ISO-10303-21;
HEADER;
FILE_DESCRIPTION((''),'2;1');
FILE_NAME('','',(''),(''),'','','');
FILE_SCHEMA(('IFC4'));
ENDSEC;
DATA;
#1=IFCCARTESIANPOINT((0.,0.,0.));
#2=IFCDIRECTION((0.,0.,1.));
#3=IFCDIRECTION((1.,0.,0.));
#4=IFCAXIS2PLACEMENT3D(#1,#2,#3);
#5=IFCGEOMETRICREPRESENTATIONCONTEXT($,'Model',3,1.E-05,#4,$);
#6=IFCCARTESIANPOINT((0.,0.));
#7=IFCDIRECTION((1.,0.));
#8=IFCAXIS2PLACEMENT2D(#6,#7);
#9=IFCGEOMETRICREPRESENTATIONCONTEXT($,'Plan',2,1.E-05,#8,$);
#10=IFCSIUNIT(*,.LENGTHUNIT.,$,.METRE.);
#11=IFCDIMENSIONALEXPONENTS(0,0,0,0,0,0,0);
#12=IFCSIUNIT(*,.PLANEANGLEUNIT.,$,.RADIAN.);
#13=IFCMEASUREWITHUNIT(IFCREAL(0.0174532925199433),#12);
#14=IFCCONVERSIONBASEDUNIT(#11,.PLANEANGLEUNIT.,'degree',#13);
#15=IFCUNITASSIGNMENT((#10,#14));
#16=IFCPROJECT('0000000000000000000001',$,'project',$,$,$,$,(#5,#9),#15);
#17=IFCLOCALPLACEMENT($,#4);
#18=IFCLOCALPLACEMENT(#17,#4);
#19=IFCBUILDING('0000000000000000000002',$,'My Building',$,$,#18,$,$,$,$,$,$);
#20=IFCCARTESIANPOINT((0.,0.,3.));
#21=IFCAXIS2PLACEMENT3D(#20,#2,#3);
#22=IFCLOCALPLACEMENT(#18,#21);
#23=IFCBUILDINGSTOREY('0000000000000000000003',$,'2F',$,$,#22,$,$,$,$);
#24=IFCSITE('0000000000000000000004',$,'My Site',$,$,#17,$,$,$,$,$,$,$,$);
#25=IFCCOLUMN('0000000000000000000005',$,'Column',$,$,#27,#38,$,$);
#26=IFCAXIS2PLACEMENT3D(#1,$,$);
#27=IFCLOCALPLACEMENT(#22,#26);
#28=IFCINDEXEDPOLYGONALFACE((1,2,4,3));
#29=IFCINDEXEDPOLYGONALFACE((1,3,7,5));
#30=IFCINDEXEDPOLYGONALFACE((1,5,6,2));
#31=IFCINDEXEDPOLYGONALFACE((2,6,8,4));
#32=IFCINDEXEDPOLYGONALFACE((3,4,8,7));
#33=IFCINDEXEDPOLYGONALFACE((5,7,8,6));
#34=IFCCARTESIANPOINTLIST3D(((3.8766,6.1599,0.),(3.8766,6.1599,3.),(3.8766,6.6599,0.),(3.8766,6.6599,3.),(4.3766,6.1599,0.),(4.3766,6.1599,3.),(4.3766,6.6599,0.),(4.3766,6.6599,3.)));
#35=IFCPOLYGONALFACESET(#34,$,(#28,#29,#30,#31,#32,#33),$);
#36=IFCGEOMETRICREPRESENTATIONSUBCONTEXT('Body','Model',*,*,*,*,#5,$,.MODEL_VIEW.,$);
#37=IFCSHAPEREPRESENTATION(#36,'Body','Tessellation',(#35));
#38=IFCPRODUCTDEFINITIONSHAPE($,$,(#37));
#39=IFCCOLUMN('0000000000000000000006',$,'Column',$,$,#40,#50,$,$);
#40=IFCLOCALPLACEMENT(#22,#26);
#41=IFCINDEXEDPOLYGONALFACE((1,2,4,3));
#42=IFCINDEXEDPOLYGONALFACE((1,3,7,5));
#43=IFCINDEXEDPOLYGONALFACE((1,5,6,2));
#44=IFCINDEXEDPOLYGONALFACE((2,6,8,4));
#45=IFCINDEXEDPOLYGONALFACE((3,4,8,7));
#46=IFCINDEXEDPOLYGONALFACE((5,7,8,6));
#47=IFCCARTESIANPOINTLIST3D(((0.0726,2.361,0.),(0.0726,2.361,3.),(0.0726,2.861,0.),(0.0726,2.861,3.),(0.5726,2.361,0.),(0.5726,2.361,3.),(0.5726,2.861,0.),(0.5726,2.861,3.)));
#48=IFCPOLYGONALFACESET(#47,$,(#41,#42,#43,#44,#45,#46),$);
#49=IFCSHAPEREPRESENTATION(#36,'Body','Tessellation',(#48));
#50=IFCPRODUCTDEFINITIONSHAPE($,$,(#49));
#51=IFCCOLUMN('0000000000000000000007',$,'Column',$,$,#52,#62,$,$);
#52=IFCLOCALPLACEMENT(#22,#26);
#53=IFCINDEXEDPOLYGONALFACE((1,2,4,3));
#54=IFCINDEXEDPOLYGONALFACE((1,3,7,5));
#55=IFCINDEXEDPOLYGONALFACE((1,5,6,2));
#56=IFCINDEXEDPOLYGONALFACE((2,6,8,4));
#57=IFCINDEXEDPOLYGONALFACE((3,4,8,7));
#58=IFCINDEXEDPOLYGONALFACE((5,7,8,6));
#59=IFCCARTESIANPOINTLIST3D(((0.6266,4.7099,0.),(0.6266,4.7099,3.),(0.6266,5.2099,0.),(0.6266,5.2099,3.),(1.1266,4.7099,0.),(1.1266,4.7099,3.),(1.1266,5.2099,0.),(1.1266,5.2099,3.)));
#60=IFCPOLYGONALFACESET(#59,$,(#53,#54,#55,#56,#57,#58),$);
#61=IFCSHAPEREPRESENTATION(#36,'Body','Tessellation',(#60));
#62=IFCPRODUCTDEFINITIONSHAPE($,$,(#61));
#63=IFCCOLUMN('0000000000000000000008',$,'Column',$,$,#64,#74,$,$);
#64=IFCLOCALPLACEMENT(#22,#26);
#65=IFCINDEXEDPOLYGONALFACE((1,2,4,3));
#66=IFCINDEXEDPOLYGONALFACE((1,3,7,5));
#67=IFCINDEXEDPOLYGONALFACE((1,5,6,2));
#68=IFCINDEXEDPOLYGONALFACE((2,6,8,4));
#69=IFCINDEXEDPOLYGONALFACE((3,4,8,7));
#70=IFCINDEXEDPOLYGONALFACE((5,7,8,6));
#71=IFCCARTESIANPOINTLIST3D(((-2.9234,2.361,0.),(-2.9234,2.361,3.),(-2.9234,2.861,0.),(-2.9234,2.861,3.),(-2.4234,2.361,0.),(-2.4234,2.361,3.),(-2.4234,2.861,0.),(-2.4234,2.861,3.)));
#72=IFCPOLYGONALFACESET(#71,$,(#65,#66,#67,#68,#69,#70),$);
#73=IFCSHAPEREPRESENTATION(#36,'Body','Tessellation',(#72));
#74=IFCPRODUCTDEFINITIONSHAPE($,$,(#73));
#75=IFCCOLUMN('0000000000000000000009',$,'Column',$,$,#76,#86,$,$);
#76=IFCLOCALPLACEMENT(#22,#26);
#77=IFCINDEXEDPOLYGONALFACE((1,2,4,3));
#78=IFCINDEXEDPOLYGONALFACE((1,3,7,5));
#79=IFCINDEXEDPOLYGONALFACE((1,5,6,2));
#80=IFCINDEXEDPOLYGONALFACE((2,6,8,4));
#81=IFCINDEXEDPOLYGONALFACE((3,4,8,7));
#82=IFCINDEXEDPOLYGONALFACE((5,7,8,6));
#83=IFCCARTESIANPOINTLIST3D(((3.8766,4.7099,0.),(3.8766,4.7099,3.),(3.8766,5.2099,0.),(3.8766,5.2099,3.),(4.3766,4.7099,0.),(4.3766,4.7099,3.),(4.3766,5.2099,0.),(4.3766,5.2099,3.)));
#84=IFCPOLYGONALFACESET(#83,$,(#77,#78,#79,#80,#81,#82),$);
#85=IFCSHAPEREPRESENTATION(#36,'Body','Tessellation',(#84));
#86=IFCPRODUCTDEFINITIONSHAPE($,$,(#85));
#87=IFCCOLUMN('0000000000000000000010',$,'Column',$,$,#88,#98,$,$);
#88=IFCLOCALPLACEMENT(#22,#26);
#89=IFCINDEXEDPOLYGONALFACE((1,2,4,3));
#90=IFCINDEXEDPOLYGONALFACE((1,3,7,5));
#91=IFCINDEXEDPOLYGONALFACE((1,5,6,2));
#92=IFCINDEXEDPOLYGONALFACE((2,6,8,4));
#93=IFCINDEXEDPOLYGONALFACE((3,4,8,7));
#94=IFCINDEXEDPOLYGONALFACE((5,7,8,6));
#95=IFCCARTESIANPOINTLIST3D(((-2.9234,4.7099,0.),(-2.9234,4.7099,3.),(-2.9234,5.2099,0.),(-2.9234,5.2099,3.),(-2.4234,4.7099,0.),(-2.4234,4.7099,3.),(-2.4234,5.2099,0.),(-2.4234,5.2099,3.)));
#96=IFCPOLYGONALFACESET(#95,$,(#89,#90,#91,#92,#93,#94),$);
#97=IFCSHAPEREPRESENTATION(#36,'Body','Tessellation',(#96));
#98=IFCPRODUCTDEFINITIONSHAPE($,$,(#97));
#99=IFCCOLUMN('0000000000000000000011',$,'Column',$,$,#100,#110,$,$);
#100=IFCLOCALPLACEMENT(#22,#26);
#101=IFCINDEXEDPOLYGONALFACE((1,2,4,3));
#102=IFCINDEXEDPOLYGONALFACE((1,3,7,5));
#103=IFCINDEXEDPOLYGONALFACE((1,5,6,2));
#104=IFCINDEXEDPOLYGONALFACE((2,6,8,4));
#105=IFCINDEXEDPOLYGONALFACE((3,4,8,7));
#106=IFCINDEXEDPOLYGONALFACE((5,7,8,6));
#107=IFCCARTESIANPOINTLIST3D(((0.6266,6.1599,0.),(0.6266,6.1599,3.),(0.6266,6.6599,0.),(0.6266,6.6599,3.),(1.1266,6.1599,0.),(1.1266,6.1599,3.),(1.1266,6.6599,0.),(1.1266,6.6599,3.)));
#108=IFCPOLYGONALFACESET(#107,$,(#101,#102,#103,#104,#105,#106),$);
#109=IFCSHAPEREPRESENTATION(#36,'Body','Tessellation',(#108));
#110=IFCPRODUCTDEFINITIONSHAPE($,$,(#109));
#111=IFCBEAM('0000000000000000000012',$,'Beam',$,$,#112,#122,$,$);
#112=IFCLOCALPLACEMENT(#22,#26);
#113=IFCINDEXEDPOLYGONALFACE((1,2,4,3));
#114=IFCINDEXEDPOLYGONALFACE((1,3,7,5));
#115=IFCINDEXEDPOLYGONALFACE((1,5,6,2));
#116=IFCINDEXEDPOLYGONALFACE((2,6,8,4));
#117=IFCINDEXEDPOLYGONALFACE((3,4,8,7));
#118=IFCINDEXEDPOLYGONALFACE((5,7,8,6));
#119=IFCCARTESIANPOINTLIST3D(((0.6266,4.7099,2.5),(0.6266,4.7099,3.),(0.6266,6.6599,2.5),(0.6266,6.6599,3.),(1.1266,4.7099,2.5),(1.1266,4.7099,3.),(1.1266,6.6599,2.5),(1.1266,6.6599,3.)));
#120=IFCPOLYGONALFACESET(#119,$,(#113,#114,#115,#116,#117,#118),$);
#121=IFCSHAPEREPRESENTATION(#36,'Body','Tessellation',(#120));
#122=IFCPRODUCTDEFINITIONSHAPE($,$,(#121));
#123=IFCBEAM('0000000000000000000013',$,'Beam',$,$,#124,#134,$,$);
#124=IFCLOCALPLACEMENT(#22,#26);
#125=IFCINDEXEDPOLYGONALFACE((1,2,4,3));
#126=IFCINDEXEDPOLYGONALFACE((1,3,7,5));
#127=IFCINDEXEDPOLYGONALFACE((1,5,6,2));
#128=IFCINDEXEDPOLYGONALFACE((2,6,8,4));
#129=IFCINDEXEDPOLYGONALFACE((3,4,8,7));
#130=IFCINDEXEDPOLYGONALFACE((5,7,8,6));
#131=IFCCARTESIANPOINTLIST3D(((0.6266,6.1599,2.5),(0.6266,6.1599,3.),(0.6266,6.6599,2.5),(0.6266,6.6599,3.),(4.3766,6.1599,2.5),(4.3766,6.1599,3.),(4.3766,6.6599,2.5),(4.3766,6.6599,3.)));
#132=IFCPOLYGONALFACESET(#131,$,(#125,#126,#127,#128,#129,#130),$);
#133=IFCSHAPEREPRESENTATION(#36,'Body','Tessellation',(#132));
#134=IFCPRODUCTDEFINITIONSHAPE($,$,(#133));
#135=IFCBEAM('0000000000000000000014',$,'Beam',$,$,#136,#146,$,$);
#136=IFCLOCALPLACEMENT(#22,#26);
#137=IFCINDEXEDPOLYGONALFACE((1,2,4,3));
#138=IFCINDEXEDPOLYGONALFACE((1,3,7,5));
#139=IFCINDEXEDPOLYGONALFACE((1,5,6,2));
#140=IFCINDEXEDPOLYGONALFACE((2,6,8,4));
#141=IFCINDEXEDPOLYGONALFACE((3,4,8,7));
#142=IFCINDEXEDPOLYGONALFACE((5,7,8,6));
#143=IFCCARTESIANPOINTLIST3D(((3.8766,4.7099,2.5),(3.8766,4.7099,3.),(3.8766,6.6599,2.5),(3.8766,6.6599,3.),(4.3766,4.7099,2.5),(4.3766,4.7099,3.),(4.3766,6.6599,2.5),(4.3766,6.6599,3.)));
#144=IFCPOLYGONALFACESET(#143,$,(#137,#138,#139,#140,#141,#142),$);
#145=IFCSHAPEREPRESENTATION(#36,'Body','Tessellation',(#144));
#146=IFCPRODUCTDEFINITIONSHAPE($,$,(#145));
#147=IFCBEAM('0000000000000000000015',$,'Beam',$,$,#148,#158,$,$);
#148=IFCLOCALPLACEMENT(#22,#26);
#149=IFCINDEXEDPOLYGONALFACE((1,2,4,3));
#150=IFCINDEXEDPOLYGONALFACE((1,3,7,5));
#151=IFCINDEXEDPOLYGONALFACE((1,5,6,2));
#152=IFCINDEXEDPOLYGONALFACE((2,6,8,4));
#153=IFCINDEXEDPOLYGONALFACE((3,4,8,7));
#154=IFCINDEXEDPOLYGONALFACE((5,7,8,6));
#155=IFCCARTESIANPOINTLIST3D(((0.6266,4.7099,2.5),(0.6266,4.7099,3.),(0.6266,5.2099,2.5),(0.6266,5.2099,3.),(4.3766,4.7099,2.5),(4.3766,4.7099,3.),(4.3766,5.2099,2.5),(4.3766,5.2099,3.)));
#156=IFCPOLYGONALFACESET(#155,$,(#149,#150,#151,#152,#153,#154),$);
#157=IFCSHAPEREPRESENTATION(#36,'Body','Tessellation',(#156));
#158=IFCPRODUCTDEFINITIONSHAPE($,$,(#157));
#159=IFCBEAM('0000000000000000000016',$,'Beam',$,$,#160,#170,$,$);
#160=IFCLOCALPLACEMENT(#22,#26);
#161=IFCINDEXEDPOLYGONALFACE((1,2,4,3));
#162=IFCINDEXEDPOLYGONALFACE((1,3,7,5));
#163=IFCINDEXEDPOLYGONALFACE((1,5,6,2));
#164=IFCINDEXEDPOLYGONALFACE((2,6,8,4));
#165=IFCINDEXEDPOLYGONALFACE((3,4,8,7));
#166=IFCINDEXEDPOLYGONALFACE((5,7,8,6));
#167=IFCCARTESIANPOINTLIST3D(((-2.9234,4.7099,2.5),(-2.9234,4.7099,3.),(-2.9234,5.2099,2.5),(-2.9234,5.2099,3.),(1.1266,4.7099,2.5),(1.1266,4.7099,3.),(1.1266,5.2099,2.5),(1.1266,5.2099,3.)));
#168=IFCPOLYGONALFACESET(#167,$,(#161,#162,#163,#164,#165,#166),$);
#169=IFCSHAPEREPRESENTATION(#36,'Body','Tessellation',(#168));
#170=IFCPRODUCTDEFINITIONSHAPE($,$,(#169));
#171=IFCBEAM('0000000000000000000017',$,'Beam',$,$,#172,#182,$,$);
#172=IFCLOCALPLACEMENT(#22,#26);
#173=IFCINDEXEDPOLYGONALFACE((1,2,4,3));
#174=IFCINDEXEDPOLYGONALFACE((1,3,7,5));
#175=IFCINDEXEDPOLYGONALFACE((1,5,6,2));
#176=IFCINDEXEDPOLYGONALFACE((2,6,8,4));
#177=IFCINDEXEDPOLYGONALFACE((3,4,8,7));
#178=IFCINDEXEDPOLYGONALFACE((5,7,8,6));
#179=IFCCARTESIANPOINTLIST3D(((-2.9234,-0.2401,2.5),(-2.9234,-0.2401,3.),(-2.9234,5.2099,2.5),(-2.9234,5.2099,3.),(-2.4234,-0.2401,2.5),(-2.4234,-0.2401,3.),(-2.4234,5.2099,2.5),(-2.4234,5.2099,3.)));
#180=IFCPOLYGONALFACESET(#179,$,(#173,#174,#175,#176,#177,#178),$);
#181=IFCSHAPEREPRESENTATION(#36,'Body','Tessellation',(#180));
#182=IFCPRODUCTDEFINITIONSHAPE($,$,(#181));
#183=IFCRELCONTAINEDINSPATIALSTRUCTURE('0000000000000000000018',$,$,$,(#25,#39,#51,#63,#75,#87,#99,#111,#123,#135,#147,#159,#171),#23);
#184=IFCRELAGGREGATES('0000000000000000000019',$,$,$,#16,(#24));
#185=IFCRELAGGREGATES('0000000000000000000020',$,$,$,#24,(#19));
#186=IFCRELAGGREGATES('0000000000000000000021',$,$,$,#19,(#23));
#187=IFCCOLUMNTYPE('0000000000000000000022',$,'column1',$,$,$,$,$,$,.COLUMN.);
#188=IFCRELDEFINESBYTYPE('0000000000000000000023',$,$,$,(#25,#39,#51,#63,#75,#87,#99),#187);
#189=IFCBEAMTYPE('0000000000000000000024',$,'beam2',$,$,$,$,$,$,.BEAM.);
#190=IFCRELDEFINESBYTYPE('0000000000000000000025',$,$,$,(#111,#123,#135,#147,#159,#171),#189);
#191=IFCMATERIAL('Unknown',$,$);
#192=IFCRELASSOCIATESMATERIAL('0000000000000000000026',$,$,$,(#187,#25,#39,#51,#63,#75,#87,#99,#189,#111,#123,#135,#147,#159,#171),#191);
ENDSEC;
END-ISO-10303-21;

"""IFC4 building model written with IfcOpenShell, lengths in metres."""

from ifc_helpers import new_model, entity, si_unit, converted_unit, frame, origin_with_axes, origin_2d_with_axis, place, context, subcontext, project, spatial, rectangle, extrude, material, material_profile, profile_set, profile_usage, type_object, element, save


model = new_model("IFC4")

# Units and contexts
model_context = context("Model", 3, precision=1e-05, world=origin_with_axes())
plan_context = context("Plan", 2, precision=1e-05, world=origin_2d_with_axis())
body_context_1 = subcontext(model_context, "Body", "Model", "MODEL_VIEW")
ifc_project = project(units=[si_unit("LENGTHUNIT", "METRE"), converted_unit("PLANEANGLEUNIT", "degree", entity("IfcReal", 0.0174532925199433), si_unit("PLANEANGLEUNIT", "RADIAN"), dimensions=[0, 0, 0, 0, 0, 0, 0])], contexts=[model_context, plan_context])

# Site, building, storey
site_placement = place(None, origin_with_axes())
site = spatial("IfcSite", under=ifc_project, at=site_placement, Name="My Site")
building_placement = place(site_placement, origin_with_axes())
building = spatial("IfcBuilding", under=site, at=building_placement, Name="My Building")
storey_placement = place(building_placement, frame((0.0, 0.0, 3.0), z_axis=(0.0, 0.0, 1.0), x_axis=(1.0, 0.0, 0.0)))
storey = spatial("IfcBuildingStorey", under=building, at=storey_placement, Name="2F")

# Columns
ifc_material = material(Name="Unknown")
ifc_material_profile_1 = material_profile(ifc_material, rectangle(XDim=0.5, YDim=0.5))
ifc_profile_set_1 = profile_set([ifc_material_profile_1])
ifc_profile_usage_1 = profile_usage(ifc_profile_set_1, cardinal=7)
column_type = type_object("IfcColumnType", Name="column1", PredefinedType="COLUMN", material=ifc_profile_set_1)
column_1_placement = place(storey_placement, frame((4.3766, 6.6599, 0.0), z_axis=(0.0, 0.0, 1.0), x_axis=(1.0, 0.0, 0.0)))
element("IfcColumn", 1, at=column_1_placement, inside=storey, type_object=column_type, material=ifc_profile_usage_1, Name="Column", context=body_context_1, shape_type="SweptSolid", body=[
    extrude(rectangle(XDim=0.5, YDim=0.5), frame((-0.25, -0.25, 0.0), z_axis=(0.0, 0.0, 1.0), x_axis=(1.0, 0.0, 0.0)), (0.0, 0.0, 1.0), 3.0),
])
ifc_profile_usage_2 = profile_usage(ifc_profile_set_1, cardinal=7)
column_2_placement = place(storey_placement, frame((0.5726, 2.861, 0.0), z_axis=(0.0, 0.0, 1.0), x_axis=(1.0, 0.0, 0.0)))
element("IfcColumn", 2, at=column_2_placement, inside=storey, type_object=column_type, material=ifc_profile_usage_2, Name="Column", context=body_context_1, shape_type="SweptSolid", body=[
    extrude(rectangle(XDim=0.5, YDim=0.5), frame((-0.25, -0.25, 0.0), z_axis=(0.0, 0.0, 1.0), x_axis=(1.0, 0.0, 0.0)), (0.0, 0.0, 1.0), 3.0),
])
ifc_profile_usage_3 = profile_usage(ifc_profile_set_1, cardinal=7)
column_3_placement = place(storey_placement, frame((1.1266, 5.2099, 0.0), z_axis=(0.0, 0.0, 1.0), x_axis=(1.0, 0.0, 0.0)))
element("IfcColumn", 3, at=column_3_placement, inside=storey, type_object=column_type, material=ifc_profile_usage_3, Name="Column", context=body_context_1, shape_type="SweptSolid", body=[
    extrude(rectangle(XDim=0.5, YDim=0.5), frame((-0.25, -0.25, 0.0), z_axis=(0.0, 0.0, 1.0), x_axis=(1.0, 0.0, 0.0)), (0.0, 0.0, 1.0), 3.0),
])
ifc_profile_usage_4 = profile_usage(ifc_profile_set_1, cardinal=7)
column_4_placement = place(storey_placement, frame((-2.4234, 2.861, 0.0), z_axis=(0.0, 0.0, 1.0), x_axis=(1.0, 0.0, 0.0)))
element("IfcColumn", 4, at=column_4_placement, inside=storey, type_object=column_type, material=ifc_profile_usage_4, Name="Column", context=body_context_1, shape_type="SweptSolid", body=[
    extrude(rectangle(XDim=0.5, YDim=0.5), frame((-0.25, -0.25, 0.0), z_axis=(0.0, 0.0, 1.0), x_axis=(1.0, 0.0, 0.0)), (0.0, 0.0, 1.0), 3.0),
])
ifc_profile_usage_5 = profile_usage(ifc_profile_set_1, cardinal=7)
column_5_placement = place(storey_placement, frame((4.3766, 5.2099, 0.0), z_axis=(0.0, 0.0, 1.0), x_axis=(1.0, 0.0, 0.0)))
element("IfcColumn", 5, at=column_5_placement, inside=storey, type_object=column_type, material=ifc_profile_usage_5, Name="Column", context=body_context_1, shape_type="SweptSolid", body=[
    extrude(rectangle(XDim=0.5, YDim=0.5), frame((-0.25, -0.25, 0.0), z_axis=(0.0, 0.0, 1.0), x_axis=(1.0, 0.0, 0.0)), (0.0, 0.0, 1.0), 3.0),
])
ifc_profile_usage_6 = profile_usage(ifc_profile_set_1, cardinal=7)
column_6_placement = place(storey_placement, frame((-2.4234, 5.2099, 0.0), z_axis=(0.0, 0.0, 1.0), x_axis=(1.0, 0.0, 0.0)))
element("IfcColumn", 6, at=column_6_placement, inside=storey, type_object=column_type, material=ifc_profile_usage_6, Name="Column", context=body_context_1, shape_type="SweptSolid", body=[
    extrude(rectangle(XDim=0.5, YDim=0.5), frame((-0.25, -0.25, 0.0), z_axis=(0.0, 0.0, 1.0), x_axis=(1.0, 0.0, 0.0)), (0.0, 0.0, 1.0), 3.0),
])
ifc_profile_usage_7 = profile_usage(ifc_profile_set_1, cardinal=7)
column_7_placement = place(storey_placement, frame((1.1266, 6.6599, 0.0), z_axis=(0.0, 0.0, 1.0), x_axis=(1.0, 0.0, 0.0)))
element("IfcColumn", 7, at=column_7_placement, inside=storey, type_object=column_type, material=ifc_profile_usage_7, Name="Column", context=body_context_1, shape_type="SweptSolid", body=[
    extrude(rectangle(XDim=0.5, YDim=0.5), frame((-0.25, -0.25, 0.0), z_axis=(0.0, 0.0, 1.0), x_axis=(1.0, 0.0, 0.0)), (0.0, 0.0, 1.0), 3.0),
])

# Beams
ifc_material_profile_2 = material_profile(ifc_material, rectangle(XDim=0.5, YDim=0.5))
ifc_profile_set_2 = profile_set([ifc_material_profile_2])
ifc_profile_usage_8 = profile_usage(ifc_profile_set_2, cardinal=7)
beam_type = type_object("IfcBeamType", Name="beam2", PredefinedType="BEAM", material=ifc_profile_set_2)
beam_1_placement = place(storey_placement, frame((1.1266, 6.6599, 3.0), z_axis=(0.0, -1.0, 0.0), x_axis=(1.0, 0.0, 0.0)))
element("IfcBeam", 8, at=beam_1_placement, inside=storey, type_object=beam_type, material=ifc_profile_usage_8, Name="Beam", context=body_context_1, shape_type="SweptSolid", body=[
    extrude(rectangle(XDim=0.5, YDim=0.5), frame((-0.25, -0.25, 0.0), z_axis=(0.0, 0.0, 1.0), x_axis=(1.0, 0.0, 0.0)), (0.0, 0.0, 1.0), 1.95),
])
ifc_profile_usage_9 = profile_usage(ifc_profile_set_2, cardinal=7)
beam_2_placement = place(storey_placement, frame((0.6266, 6.6599, 3.0), z_axis=(1.0, 0.0, 0.0), x_axis=(0.0, 1.0, 0.0)))
element("IfcBeam", 9, at=beam_2_placement, inside=storey, type_object=beam_type, material=ifc_profile_usage_9, Name="Beam", context=body_context_1, shape_type="SweptSolid", body=[
    extrude(rectangle(XDim=0.5, YDim=0.5), frame((-0.25, -0.25, 0.0), z_axis=(0.0, 0.0, 1.0), x_axis=(1.0, 0.0, 0.0)), (0.0, 0.0, 1.0), 3.75),
])
ifc_profile_usage_10 = profile_usage(ifc_profile_set_2, cardinal=7)
beam_3_placement = place(storey_placement, frame((3.8766, 4.7099, 3.0), z_axis=(0.0, 1.0, 0.0), x_axis=(-1.0, 0.0, 0.0)))
element("IfcBeam", 10, at=beam_3_placement, inside=storey, type_object=beam_type, material=ifc_profile_usage_10, Name="Beam", context=body_context_1, shape_type="SweptSolid", body=[
    extrude(rectangle(XDim=0.5, YDim=0.5), frame((-0.25, -0.25, 0.0), z_axis=(0.0, 0.0, 1.0), x_axis=(1.0, 0.0, 0.0)), (0.0, 0.0, 1.0), 1.95),
])
ifc_profile_usage_11 = profile_usage(ifc_profile_set_2, cardinal=7)
beam_4_placement = place(storey_placement, frame((4.3766, 4.7099, 3.0), z_axis=(-1.0, 0.0, 0.0), x_axis=(0.0, -1.0, 0.0)))
element("IfcBeam", 11, at=beam_4_placement, inside=storey, type_object=beam_type, material=ifc_profile_usage_11, Name="Beam", context=body_context_1, shape_type="SweptSolid", body=[
    extrude(rectangle(XDim=0.5, YDim=0.5), frame((-0.25, -0.25, 0.0), z_axis=(0.0, 0.0, 1.0), x_axis=(1.0, 0.0, 0.0)), (0.0, 0.0, 1.0), 3.75),
])
ifc_profile_usage_12 = profile_usage(ifc_profile_set_2, cardinal=7)
beam_5_placement = place(storey_placement, frame((1.1266, 4.7099, 3.0), z_axis=(-1.0, 0.0, 0.0), x_axis=(0.0, -1.0, 0.0)))
element("IfcBeam", 12, at=beam_5_placement, inside=storey, type_object=beam_type, material=ifc_profile_usage_12, Name="Beam", context=body_context_1, shape_type="SweptSolid", body=[
    extrude(rectangle(XDim=0.5, YDim=0.5), frame((-0.25, -0.25, 0.0), z_axis=(0.0, 0.0, 1.0), x_axis=(1.0, 0.0, 0.0)), (0.0, 0.0, 1.0), 4.05),
])
ifc_profile_usage_13 = profile_usage(ifc_profile_set_2, cardinal=7)
beam_6_placement = place(storey_placement, frame((-2.4234, 5.2099, 3.0), z_axis=(0.0, -1.0, 0.0), x_axis=(1.0, 0.0, 0.0)))
element("IfcBeam", 13, at=beam_6_placement, inside=storey, type_object=beam_type, material=ifc_profile_usage_13, Name="Beam", context=body_context_1, shape_type="SweptSolid", body=[
    extrude(rectangle(XDim=0.5, YDim=0.5), frame((-0.25, -0.25, 0.0), z_axis=(0.0, 0.0, 1.0), x_axis=(1.0, 0.0, 0.0)), (0.0, 0.0, 1.0), 5.45),
])

save(model, "model.ifc")
